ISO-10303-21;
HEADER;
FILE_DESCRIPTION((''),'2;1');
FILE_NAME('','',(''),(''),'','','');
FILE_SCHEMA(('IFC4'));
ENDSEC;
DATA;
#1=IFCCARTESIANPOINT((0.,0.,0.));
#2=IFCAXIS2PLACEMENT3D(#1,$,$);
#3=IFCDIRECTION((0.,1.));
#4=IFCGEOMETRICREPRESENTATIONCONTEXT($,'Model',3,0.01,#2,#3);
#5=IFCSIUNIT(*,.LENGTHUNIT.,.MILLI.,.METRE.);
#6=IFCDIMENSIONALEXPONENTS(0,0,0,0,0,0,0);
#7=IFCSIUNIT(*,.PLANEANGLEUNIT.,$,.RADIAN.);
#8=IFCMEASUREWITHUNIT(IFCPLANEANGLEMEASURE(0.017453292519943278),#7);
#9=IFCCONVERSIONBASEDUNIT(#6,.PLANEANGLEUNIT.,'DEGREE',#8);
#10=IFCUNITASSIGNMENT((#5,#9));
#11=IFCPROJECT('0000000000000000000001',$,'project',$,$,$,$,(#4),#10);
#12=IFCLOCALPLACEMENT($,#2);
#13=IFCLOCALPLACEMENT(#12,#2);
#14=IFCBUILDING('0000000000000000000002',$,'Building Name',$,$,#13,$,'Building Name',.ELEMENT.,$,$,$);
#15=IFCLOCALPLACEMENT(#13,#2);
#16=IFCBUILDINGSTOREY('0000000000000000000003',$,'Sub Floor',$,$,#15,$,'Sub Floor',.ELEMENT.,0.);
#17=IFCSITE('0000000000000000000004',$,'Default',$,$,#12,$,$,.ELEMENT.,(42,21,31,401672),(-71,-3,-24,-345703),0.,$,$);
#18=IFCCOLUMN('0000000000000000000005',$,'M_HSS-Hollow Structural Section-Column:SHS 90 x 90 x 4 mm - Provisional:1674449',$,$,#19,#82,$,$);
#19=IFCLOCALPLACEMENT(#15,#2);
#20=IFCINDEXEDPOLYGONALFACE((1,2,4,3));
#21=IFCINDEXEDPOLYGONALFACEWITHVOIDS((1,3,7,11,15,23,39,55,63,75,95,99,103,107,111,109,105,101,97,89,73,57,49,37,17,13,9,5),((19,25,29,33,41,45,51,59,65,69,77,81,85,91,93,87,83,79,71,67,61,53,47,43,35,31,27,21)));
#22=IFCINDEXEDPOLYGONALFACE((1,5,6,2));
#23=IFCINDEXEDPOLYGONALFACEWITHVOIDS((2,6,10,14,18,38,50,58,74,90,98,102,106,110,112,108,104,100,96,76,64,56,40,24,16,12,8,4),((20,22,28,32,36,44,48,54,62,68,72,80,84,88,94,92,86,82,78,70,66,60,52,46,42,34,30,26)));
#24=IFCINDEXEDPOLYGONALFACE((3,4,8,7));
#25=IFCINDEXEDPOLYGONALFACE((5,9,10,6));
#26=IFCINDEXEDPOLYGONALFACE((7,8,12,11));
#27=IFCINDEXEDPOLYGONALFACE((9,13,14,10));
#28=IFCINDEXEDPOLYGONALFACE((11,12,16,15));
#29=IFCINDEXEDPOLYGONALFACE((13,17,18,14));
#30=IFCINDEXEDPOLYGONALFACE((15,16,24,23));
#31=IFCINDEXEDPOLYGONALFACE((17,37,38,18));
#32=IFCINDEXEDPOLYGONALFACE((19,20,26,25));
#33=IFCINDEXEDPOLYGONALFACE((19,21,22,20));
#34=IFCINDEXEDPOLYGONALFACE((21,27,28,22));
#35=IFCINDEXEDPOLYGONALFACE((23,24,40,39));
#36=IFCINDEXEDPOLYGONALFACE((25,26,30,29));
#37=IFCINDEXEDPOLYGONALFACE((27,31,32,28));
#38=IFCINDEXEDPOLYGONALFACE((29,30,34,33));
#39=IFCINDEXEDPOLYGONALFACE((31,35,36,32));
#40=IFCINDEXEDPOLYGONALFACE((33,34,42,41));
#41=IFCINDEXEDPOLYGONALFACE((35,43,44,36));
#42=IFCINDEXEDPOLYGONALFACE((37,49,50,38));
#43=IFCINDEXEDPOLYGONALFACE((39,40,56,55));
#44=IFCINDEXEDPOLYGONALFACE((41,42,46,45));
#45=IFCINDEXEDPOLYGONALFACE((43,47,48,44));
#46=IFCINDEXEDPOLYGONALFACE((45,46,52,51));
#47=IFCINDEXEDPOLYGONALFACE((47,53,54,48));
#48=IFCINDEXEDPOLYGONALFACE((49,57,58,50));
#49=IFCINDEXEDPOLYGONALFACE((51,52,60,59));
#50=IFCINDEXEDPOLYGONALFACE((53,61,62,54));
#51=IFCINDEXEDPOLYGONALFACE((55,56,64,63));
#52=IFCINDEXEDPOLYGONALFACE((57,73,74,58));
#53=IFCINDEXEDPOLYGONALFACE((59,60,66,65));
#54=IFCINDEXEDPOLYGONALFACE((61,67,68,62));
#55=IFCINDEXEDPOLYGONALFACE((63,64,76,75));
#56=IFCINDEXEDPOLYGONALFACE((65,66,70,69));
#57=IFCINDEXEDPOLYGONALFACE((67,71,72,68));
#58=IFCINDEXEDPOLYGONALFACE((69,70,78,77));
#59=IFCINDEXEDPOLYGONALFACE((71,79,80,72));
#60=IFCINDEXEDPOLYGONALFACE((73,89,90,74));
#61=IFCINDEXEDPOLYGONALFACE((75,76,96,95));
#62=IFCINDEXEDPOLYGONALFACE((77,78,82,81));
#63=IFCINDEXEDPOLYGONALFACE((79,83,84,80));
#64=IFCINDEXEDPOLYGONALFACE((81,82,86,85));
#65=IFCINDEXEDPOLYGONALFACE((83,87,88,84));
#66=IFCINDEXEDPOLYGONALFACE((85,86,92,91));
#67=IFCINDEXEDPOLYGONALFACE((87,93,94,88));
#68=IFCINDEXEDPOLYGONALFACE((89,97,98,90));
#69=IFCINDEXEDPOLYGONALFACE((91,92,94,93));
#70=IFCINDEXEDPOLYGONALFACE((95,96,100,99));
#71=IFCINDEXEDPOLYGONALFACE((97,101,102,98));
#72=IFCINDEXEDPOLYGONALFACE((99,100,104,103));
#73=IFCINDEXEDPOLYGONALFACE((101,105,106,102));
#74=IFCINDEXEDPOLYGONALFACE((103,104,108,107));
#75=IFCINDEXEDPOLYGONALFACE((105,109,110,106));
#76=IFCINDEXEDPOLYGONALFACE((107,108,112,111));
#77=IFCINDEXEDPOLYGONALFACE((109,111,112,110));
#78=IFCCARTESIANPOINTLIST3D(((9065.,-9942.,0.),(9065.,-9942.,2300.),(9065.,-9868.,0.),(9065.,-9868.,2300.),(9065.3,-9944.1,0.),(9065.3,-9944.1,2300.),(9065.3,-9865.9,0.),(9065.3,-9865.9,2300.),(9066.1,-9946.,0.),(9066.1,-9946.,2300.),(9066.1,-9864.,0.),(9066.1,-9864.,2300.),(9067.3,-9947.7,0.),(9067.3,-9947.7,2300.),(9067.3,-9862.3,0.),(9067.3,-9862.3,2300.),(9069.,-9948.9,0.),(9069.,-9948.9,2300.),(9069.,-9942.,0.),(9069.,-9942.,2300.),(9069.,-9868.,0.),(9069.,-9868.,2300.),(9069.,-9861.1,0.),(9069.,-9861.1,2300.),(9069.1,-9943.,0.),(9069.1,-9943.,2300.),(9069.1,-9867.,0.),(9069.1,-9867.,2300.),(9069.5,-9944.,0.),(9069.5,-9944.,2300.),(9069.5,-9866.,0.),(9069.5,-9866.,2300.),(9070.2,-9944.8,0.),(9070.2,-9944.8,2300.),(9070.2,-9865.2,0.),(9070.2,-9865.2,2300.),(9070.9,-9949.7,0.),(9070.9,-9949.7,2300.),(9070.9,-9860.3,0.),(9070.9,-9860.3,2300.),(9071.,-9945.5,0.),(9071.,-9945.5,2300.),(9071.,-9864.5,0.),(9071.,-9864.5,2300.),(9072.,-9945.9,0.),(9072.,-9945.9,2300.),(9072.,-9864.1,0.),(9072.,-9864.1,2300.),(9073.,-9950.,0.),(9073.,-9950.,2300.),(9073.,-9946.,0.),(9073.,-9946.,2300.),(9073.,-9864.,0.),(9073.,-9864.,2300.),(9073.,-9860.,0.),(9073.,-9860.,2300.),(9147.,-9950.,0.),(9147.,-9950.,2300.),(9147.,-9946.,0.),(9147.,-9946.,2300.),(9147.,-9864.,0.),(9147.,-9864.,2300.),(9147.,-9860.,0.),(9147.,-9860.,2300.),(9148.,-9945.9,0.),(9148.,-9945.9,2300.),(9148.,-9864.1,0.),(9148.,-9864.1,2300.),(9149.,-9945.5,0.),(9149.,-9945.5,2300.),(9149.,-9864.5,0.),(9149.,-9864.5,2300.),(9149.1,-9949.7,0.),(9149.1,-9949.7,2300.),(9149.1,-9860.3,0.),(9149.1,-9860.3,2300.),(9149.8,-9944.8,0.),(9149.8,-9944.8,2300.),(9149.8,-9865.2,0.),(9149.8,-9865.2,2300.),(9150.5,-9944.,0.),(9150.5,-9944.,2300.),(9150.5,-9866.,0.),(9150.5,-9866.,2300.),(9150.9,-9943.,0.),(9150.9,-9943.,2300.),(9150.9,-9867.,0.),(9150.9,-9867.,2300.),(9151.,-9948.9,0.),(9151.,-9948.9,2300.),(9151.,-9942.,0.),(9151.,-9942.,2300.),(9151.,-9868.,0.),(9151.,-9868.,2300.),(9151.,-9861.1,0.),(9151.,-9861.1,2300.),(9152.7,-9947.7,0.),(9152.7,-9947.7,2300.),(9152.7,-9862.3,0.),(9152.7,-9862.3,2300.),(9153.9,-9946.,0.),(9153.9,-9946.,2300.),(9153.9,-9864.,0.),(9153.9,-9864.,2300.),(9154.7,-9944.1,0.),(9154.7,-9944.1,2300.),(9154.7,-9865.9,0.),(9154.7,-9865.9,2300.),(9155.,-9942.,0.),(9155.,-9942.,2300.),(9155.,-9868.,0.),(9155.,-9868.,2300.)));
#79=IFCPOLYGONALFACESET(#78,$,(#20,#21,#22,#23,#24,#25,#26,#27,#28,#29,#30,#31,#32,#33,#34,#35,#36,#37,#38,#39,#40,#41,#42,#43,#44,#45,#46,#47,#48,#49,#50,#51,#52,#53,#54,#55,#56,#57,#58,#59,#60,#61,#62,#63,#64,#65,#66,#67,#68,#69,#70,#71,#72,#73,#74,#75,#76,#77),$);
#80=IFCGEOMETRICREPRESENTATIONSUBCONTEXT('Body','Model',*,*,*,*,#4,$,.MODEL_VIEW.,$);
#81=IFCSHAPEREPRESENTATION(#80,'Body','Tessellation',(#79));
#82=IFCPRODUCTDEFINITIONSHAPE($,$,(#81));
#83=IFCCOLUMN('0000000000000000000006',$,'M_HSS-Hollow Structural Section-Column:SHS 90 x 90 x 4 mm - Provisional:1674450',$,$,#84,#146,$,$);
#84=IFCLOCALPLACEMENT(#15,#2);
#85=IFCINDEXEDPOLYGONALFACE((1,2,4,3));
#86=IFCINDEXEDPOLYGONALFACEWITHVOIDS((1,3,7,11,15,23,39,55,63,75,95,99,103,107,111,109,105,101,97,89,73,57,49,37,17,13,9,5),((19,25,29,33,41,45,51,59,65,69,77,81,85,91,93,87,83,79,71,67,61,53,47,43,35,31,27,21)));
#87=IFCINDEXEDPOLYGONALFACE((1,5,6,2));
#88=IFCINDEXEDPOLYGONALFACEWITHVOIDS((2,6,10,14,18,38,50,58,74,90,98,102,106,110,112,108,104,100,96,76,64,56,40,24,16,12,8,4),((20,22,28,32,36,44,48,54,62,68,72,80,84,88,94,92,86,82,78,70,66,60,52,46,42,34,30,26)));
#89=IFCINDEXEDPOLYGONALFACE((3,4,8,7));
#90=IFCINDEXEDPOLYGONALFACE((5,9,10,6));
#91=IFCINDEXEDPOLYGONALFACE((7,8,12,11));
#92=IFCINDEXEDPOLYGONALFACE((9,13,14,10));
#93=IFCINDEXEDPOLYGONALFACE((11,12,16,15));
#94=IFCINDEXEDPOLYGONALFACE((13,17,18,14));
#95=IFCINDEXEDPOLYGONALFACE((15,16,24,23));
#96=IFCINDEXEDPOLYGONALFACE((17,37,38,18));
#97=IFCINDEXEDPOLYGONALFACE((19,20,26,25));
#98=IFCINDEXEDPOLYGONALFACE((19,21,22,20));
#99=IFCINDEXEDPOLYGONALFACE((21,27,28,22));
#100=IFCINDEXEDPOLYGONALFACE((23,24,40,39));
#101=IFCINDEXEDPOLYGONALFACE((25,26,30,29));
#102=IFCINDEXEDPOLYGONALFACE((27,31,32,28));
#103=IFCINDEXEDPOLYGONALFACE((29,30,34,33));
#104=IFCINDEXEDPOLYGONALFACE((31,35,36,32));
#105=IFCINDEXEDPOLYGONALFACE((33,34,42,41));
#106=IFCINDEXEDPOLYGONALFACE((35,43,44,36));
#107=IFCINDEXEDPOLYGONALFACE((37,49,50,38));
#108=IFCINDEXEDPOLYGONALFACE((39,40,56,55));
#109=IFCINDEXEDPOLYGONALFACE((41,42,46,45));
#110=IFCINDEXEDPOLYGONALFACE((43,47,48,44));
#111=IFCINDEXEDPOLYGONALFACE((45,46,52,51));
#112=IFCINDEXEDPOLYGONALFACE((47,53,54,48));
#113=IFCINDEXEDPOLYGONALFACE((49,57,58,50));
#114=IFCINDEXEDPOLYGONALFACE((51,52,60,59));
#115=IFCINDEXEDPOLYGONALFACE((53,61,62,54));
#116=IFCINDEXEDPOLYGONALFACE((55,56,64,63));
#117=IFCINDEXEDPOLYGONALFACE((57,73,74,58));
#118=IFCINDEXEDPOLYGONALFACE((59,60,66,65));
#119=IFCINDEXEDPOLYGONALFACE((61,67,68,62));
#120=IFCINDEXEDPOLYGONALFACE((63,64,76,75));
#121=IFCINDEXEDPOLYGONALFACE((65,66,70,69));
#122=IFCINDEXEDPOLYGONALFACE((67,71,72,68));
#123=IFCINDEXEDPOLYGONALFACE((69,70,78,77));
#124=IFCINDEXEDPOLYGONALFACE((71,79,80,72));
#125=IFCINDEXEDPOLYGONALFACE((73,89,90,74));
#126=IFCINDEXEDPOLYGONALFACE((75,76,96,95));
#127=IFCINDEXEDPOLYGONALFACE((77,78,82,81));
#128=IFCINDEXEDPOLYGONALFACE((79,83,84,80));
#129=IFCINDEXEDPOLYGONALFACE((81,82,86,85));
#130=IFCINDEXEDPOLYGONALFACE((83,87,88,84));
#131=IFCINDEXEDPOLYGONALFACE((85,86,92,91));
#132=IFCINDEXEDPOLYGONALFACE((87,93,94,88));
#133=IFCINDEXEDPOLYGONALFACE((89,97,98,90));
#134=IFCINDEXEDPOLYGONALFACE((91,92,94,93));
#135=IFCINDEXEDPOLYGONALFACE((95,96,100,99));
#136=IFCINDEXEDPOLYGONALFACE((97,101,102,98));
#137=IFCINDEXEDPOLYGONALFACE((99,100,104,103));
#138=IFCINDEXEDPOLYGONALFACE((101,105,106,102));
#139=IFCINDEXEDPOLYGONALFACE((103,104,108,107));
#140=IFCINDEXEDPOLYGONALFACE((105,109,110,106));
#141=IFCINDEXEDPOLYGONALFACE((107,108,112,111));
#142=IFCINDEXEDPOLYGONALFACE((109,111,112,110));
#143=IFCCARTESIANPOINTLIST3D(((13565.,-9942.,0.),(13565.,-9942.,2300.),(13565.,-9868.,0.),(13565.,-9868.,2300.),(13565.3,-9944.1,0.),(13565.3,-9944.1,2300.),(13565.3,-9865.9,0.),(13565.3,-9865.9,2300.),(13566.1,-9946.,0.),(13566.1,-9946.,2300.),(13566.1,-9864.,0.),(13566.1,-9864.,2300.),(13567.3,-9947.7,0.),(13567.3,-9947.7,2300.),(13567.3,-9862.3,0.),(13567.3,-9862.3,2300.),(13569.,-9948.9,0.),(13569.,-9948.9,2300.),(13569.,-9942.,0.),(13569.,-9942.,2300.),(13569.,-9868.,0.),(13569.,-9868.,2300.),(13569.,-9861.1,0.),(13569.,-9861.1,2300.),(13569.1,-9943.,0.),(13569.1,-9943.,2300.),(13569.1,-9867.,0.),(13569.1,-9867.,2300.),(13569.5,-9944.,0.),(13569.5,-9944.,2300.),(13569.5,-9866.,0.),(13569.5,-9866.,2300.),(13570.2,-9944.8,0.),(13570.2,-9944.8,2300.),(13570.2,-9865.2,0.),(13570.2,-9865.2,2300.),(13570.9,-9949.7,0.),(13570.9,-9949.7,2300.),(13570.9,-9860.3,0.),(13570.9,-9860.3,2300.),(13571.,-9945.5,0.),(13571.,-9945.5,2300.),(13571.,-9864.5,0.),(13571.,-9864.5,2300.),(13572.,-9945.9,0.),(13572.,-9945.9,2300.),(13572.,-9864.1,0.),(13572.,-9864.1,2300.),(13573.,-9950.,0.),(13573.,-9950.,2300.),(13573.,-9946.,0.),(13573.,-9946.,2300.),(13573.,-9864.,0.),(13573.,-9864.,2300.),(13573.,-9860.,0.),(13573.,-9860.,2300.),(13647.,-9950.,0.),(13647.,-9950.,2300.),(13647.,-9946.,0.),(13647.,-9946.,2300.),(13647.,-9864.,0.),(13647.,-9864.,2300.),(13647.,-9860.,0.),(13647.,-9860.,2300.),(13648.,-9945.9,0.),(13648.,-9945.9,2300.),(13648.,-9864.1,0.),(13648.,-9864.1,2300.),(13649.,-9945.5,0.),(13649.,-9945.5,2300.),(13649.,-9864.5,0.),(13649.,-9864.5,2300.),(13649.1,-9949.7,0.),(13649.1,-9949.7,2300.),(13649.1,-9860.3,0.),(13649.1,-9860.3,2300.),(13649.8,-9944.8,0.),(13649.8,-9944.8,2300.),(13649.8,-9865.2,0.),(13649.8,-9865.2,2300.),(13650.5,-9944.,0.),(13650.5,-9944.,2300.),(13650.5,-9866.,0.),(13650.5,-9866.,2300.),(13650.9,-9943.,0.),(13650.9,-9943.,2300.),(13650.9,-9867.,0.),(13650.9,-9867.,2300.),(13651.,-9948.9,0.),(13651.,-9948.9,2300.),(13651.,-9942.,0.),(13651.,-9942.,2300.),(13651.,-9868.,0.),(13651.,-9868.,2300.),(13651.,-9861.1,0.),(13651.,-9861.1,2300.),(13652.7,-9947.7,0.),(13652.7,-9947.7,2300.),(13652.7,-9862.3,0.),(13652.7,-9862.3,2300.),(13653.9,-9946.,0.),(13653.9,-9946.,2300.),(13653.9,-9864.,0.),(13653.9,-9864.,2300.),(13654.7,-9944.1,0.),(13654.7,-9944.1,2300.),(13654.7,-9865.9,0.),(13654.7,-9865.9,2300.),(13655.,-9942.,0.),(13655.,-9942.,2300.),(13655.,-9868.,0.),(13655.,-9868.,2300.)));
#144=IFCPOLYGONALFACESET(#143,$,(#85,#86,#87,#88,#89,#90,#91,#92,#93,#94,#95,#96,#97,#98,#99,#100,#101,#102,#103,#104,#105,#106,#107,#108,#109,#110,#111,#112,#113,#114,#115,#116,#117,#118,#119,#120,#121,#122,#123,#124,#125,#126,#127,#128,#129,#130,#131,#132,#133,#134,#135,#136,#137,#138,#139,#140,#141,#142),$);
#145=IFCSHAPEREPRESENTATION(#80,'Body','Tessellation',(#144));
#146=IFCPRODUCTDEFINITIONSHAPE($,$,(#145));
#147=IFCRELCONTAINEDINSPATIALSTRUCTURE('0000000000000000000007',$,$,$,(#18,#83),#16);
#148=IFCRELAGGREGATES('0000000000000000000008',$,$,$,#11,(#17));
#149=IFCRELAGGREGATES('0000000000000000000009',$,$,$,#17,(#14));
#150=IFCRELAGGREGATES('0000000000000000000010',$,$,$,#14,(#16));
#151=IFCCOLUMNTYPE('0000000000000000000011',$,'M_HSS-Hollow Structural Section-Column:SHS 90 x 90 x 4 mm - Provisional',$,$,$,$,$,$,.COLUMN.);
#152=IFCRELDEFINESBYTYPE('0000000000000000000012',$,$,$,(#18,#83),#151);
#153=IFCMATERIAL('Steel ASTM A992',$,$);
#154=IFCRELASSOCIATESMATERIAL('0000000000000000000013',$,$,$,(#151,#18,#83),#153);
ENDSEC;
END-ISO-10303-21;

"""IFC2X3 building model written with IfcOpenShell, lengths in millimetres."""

from ifc_helpers import new_model, entity, si_unit, converted_unit, direction, frame, frame_2d, origin, place, context, subcontext, project, spatial, polyline, circle_curve, parameter, trimmed, segment, composite_curve, outline, extrude, source, transform, mapped, material, type_object, type_shapes, element, save


model = new_model("IFC2X3")

# Units and contexts
model_context = context("Model", 3, precision=0.01, world=origin(), true_north=direction((0.0, 1.0)))
body_context = subcontext(model_context, "Body", "Model", "MODEL_VIEW")
ifc_project = project(units=[si_unit("LENGTHUNIT", "METRE", prefix="MILLI"), converted_unit("PLANEANGLEUNIT", "DEGREE", entity("IfcPlaneAngleMeasure", 0.017453292519943278), si_unit("PLANEANGLEUNIT", "RADIAN"), dimensions=[0, 0, 0, 0, 0, 0, 0])], contexts=[model_context])

# Site, building, storey
site_placement = place(None, origin())
site = spatial("IfcSite", under=ifc_project, at=site_placement, Name="Default", CompositionType="ELEMENT", RefLatitude=(42, 21, 31, 401672), RefLongitude=(-71, -3, -24, -345703), RefElevation=0.0)
building_placement = place(site_placement, origin())
building = spatial("IfcBuilding", under=site, at=building_placement, Name="Building Name", LongName="Building Name", CompositionType="ELEMENT")
storey_placement = place(building_placement, origin())
storey = spatial("IfcBuildingStorey", under=building, at=storey_placement, Name="Sub Floor", LongName="Sub Floor", CompositionType="ELEMENT", Elevation=0.0)

# Columns
ifc_material_1 = material(Name="Steel ASTM A992")
column_type = type_object("IfcColumnType", Name="M_HSS-Hollow Structural Section-Column:SHS 90 x 90 x 4 mm - Provisional", PredefinedType="COLUMN", material=ifc_material_1)
shared_shape_1 = source(origin(), body_context, "Body", "SweptSolid", [
    extrude(outline(composite_curve([segment(polyline([(-37.0, -45.0), (37.0, -45.0)]), True, "CONTINUOUS"), segment(trimmed(circle_curve(frame_2d((37.0, -37.0), x_axis=(-1.0, 0.0)), 8.0), [parameter(90.0)], [parameter(180.0)], True, "PARAMETER"), True, "CONTINUOUS"), segment(polyline([(45.0, -37.0), (45.0, 37.0)]), True, "CONTINUOUS"), segment(trimmed(circle_curve(frame_2d((37.0, 37.0), x_axis=(-1.0, 0.0)), 8.0), [parameter(180.0)], [parameter(270.0)], True, "PARAMETER"), True, "CONTINUOUS"), segment(polyline([(37.0, 45.0), (-37.0, 45.0)]), True, "CONTINUOUS"), segment(trimmed(circle_curve(frame_2d((-37.0, 37.0), x_axis=(-1.0, 0.0)), 8.0), [parameter(270.0)], [parameter(360.0)], True, "PARAMETER"), True, "CONTINUOUS"), segment(polyline([(-45.0, 37.0), (-45.0, -37.0)]), True, "CONTINUOUS"), segment(trimmed(circle_curve(frame_2d((-37.0, -37.0), x_axis=(-1.0, 0.0)), 8.0), [parameter(360.0)], [parameter(90.0)], True, "PARAMETER"), True, "CONTINUOUS")], self_intersect=False), holes=[composite_curve([segment(trimmed(circle_curve(frame_2d((-37.0, -37.0), x_axis=(-1.0, 0.0)), 4.0), [parameter(0.0)], [parameter(90.0)], True, "PARAMETER"), False, "CONTINUOUS"), segment(polyline([(-41.0, -37.0), (-41.0, 37.0)]), True, "CONTINUOUS"), segment(trimmed(circle_curve(frame_2d((-37.0, 37.0), x_axis=(-1.0, 0.0)), 4.0), [parameter(270.0)], [parameter(0.0)], True, "PARAMETER"), False, "CONTINUOUS"), segment(polyline([(-37.0, 41.0), (37.0, 41.0)]), True, "CONTINUOUS"), segment(trimmed(circle_curve(frame_2d((37.0, 37.0), x_axis=(-1.0, 0.0)), 4.0), [parameter(180.0)], [parameter(270.0)], True, "PARAMETER"), False, "CONTINUOUS"), segment(polyline([(41.0, 37.0), (41.0, -37.0)]), True, "CONTINUOUS"), segment(trimmed(circle_curve(frame_2d((37.0, -37.0), x_axis=(-1.0, 0.0)), 4.0), [parameter(90.0)], [parameter(180.0)], True, "PARAMETER"), False, "CONTINUOUS"), segment(polyline([(37.0, -41.0), (-37.0, -41.0)]), True, "CONTINUOUS")], self_intersect=False)]), frame((0.0, 0.0, 0.0), z_axis=(0.0, 0.0, 1.0), x_axis=(-1.0, 0.0, 0.0)), (0.0, 0.0, 1.0), 2300.0),
])
type_shapes(column_type, [shared_shape_1])
for number, where, name in (
    (1, (9110.0, -9905.0, 0.0), "M_HSS-Hollow Structural Section-Column:SHS 90 x 90 x 4 mm - Provisional:1674449"),
    (2, (13610.0, -9905.0, 0.0), "M_HSS-Hollow Structural Section-Column:SHS 90 x 90 x 4 mm - Provisional:1674450"),
):
    element("IfcColumn", number, at=place(storey_placement, frame(where)), inside=storey, type_object=column_type, material=ifc_material_1, Name=name, context=body_context, shape_type="MappedRepresentation", body=[
        mapped(shared_shape_1, transform((0.0, 0.0, 0.0), scale=1.0)),
    ])

save(model, "model.ifc")
